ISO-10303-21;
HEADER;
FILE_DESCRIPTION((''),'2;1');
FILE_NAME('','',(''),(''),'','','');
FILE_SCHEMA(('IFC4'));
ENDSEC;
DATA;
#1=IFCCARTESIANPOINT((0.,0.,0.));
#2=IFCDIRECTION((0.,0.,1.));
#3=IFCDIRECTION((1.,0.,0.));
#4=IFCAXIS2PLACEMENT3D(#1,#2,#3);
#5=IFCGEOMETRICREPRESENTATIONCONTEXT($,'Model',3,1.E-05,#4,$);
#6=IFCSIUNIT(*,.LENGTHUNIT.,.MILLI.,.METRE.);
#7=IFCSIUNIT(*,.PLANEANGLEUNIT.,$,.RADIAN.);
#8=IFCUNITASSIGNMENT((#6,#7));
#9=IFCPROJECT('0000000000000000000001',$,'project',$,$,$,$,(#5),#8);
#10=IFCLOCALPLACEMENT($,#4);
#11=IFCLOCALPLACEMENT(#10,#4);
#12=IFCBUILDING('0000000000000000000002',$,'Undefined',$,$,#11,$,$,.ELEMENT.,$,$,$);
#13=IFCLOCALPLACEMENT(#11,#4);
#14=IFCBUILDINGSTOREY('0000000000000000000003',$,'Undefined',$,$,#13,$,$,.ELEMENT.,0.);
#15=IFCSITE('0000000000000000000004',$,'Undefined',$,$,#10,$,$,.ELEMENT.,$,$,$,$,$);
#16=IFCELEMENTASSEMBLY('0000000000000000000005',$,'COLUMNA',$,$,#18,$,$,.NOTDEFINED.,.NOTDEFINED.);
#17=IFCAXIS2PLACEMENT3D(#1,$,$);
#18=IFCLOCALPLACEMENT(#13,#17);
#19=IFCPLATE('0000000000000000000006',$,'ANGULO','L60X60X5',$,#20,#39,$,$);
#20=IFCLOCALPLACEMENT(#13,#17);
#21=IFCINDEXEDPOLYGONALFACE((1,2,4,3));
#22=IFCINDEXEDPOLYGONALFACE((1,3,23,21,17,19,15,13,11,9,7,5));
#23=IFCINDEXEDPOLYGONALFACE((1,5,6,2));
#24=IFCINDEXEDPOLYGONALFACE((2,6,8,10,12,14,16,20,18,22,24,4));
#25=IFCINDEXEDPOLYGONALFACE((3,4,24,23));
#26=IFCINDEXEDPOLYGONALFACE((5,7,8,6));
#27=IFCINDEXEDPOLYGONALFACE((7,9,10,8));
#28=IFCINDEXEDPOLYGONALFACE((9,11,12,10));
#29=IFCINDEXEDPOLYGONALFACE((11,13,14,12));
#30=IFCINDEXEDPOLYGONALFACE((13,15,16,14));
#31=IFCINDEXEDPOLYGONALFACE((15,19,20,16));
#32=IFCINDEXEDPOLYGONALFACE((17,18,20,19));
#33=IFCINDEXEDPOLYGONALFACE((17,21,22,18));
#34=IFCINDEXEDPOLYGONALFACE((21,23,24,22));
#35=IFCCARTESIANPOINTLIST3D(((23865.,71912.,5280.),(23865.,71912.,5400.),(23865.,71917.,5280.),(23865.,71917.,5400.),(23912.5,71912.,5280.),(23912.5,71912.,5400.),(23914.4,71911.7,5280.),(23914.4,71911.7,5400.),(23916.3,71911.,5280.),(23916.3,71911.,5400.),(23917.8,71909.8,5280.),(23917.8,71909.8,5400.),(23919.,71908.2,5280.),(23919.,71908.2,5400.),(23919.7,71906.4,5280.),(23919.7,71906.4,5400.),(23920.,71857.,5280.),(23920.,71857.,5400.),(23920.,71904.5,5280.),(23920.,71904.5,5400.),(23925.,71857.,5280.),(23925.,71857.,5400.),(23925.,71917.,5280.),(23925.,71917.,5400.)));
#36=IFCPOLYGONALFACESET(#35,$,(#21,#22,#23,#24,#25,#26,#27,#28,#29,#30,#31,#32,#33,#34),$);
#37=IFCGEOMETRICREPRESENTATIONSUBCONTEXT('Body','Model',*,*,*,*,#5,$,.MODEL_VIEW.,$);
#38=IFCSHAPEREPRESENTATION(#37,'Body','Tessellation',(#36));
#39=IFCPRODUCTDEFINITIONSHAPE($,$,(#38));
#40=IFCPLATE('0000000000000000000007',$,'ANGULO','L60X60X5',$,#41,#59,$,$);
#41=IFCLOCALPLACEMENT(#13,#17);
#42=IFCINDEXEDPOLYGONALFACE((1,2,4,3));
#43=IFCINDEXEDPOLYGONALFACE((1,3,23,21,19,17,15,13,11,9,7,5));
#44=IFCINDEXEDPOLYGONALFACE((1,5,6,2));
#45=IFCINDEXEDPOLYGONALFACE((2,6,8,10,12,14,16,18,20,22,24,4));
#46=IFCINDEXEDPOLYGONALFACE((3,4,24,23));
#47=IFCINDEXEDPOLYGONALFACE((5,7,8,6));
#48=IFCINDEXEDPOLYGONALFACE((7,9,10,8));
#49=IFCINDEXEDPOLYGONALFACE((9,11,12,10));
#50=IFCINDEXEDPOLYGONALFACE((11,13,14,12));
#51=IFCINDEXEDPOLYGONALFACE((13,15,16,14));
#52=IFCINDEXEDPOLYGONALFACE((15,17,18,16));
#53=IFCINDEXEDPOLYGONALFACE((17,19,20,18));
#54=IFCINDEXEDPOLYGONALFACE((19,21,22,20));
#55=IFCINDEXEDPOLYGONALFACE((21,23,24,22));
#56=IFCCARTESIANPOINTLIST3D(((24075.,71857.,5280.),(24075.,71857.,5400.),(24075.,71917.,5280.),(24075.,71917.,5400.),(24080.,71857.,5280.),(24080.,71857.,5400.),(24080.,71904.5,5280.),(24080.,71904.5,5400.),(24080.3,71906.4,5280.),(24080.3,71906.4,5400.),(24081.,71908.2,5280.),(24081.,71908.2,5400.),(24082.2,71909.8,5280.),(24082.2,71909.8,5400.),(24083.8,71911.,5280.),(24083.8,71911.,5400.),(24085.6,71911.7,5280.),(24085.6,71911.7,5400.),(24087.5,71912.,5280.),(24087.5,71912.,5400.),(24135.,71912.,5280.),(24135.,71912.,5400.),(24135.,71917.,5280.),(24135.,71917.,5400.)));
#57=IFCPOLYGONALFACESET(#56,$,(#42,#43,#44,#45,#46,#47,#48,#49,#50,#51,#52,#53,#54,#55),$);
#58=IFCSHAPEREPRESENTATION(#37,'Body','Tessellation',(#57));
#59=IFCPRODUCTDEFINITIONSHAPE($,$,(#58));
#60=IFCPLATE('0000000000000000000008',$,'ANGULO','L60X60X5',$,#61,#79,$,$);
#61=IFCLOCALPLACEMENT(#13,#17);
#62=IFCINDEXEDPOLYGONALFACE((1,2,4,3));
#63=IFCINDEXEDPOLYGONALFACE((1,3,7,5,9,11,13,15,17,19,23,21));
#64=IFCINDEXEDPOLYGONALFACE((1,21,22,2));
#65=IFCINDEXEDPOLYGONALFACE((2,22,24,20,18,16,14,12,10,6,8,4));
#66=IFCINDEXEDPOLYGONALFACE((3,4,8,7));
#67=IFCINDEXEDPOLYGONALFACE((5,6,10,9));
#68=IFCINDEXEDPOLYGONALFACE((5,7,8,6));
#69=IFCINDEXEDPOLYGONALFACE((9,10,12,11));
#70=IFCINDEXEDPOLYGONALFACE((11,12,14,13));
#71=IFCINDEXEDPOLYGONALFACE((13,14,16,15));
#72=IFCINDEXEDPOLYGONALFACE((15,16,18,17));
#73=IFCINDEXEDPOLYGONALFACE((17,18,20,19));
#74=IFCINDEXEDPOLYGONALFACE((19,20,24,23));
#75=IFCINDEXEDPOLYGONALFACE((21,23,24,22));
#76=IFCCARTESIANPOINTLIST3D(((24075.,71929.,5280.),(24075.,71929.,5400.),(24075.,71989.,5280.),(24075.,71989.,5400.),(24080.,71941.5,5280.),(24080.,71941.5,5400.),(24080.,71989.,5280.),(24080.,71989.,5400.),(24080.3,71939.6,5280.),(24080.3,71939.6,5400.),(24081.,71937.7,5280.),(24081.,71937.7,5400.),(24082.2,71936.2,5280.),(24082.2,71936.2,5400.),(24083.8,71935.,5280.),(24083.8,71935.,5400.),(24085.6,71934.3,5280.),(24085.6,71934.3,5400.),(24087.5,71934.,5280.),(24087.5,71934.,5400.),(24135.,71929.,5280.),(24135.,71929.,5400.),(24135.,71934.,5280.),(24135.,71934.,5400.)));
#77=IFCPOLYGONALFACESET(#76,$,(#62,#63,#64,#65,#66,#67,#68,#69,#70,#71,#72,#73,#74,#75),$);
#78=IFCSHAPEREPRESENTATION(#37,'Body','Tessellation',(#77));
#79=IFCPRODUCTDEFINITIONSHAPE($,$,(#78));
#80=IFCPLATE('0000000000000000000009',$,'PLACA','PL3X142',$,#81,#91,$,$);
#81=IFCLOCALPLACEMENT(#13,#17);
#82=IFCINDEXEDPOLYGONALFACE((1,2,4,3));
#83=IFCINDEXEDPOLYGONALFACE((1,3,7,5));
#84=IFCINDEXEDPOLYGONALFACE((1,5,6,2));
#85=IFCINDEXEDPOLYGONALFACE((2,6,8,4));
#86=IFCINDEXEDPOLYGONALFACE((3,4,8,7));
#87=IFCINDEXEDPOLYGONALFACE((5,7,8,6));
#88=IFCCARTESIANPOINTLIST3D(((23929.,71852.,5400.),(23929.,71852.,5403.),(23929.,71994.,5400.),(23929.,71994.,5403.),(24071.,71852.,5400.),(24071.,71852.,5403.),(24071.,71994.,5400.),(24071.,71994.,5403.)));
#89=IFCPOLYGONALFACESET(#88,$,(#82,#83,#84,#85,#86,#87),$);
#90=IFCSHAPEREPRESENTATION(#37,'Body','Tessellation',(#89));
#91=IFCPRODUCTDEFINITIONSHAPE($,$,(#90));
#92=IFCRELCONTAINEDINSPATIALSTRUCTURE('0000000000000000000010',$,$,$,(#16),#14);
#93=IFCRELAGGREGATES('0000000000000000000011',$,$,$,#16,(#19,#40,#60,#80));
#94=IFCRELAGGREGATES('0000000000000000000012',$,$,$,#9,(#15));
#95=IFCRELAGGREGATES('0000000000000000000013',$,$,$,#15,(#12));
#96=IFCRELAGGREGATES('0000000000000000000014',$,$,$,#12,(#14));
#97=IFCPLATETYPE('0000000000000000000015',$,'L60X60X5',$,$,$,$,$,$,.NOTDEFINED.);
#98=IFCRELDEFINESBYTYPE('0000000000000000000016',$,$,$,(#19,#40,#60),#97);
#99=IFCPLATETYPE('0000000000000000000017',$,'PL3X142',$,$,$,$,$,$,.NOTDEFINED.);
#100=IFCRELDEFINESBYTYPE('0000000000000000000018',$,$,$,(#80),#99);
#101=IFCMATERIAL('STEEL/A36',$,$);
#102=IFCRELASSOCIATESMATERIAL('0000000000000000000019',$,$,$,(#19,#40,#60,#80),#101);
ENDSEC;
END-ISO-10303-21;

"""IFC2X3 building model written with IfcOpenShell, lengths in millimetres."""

from ifc_helpers import new_model, si_unit, frame, origin_with_axes, origin_2d_with_axis, place, context, subcontext, project, spatial, polyline, l_section, outline, extrude, material, type_object, element, aggregate, save


model = new_model("IFC2X3")

# Units and contexts
model_context = context("Model", 3, precision=1e-05, world=origin_with_axes())
body_context = subcontext(model_context, "Body", "Model", "MODEL_VIEW")
ifc_project = project(units=[si_unit("LENGTHUNIT", "METRE", prefix="MILLI"), si_unit("PLANEANGLEUNIT", "RADIAN")], contexts=[model_context])

# Site, building, storey
site_placement = place(None, origin_with_axes())
site = spatial("IfcSite", under=ifc_project, at=site_placement, Name="Undefined", CompositionType="ELEMENT")
building_placement = place(site_placement, origin_with_axes())
building = spatial("IfcBuilding", under=site, at=building_placement, Name="Undefined", CompositionType="ELEMENT")
storey_placement = place(building_placement, origin_with_axes())
storey = spatial("IfcBuildingStorey", under=building, at=storey_placement, Name="Undefined", CompositionType="ELEMENT", Elevation=0.0)

# Shared definitions
ifc_material_1 = material(Name="STEEL/A36")

# Element assembly, plates
assembly_1_placement = place(storey_placement, origin_with_axes())
assembly_1 = element("IfcElementAssembly", 1, at=assembly_1_placement, inside=storey, Name="COLUMNA", AssemblyPlace="NOTDEFINED", PredefinedType="NOTDEFINED")
plate_type_1 = type_object("IfcPlateType", Name="L60X60X5", PredefinedType="NOTDEFINED")
plate_1_placement = place(assembly_1_placement, frame((23895.0, 71887.0, 5400.0), z_axis=(0.0, -1.0, 0.0), x_axis=(0.0, 0.0, -1.0)))
plate_1 = element("IfcPlate", 2, at=plate_1_placement, type_object=plate_type_1, material=ifc_material_1, Name="ANGULO", Description="L60X60X5", context=body_context, shape_type="SweptSolid", body=[
    extrude(l_section(Depth=60.0, Width=60.0, Thickness=5.0, FilletRadius=7.5, at=origin_2d_with_axis()), frame((120.0, 0.0, 0.0), z_axis=(-1.0, 0.0, 0.0), x_axis=(0.0, -1.0, 0.0)), (0.0, 0.0, 1.0), 120.0),
])
plate_2_placement = place(assembly_1_placement, frame((24105.0, 71887.0, 5280.0), z_axis=(0.0, -1.0, 0.0), x_axis=(0.0, 0.0, 1.0)))
plate_2 = element("IfcPlate", 3, at=plate_2_placement, type_object=plate_type_1, material=ifc_material_1, Name="ANGULO", Description="L60X60X5", context=body_context, shape_type="SweptSolid", body=[
    extrude(l_section(Depth=60.0, Width=60.0, Thickness=5.0, FilletRadius=7.5, at=origin_2d_with_axis()), frame((120.0, 0.0, 0.0), z_axis=(-1.0, 0.0, 0.0), x_axis=(0.0, -1.0, 0.0)), (0.0, 0.0, 1.0), 120.0),
])
plate_3_placement = place(assembly_1_placement, frame((24105.0, 71959.0, 5400.0), z_axis=(0.0, 1.0, 0.0), x_axis=(0.0, 0.0, -1.0)))
plate_3 = element("IfcPlate", 4, at=plate_3_placement, type_object=plate_type_1, material=ifc_material_1, Name="ANGULO", Description="L60X60X5", context=body_context, shape_type="SweptSolid", body=[
    extrude(l_section(Depth=60.0, Width=60.0, Thickness=5.0, FilletRadius=7.5, at=origin_2d_with_axis()), frame((120.0, 0.0, 0.0), z_axis=(-1.0, 0.0, 0.0), x_axis=(0.0, -1.0, 0.0)), (0.0, 0.0, 1.0), 120.0),
])
plate_type_2 = type_object("IfcPlateType", Name="PL3X142", PredefinedType="NOTDEFINED")
plate_4_placement = place(assembly_1_placement, frame((24071.0, 71994.0, 5401.5), z_axis=(0.0, 0.0, -1.0), x_axis=(0.0, -1.0, 0.0)))
plate_4 = element("IfcPlate", 5, at=plate_4_placement, type_object=plate_type_2, material=ifc_material_1, Name="PLACA", Description="PL3X142", context=body_context, shape_type="SweptSolid", body=[
    extrude(outline(polyline([(0.0, 0.0), (142.0, 0.0), (142.0, 142.0), (0.0, 142.0), (0.0, 0.0)])), frame((0.0, 0.0, -1.5), z_axis=(0.0, 0.0, 1.0), x_axis=(1.0, 0.0, 0.0)), (0.0, 0.0, 1.0), 3.0),
])

aggregate(assembly_1, [plate_1, plate_2, plate_3, plate_4])

save(model, "model.ifc")
